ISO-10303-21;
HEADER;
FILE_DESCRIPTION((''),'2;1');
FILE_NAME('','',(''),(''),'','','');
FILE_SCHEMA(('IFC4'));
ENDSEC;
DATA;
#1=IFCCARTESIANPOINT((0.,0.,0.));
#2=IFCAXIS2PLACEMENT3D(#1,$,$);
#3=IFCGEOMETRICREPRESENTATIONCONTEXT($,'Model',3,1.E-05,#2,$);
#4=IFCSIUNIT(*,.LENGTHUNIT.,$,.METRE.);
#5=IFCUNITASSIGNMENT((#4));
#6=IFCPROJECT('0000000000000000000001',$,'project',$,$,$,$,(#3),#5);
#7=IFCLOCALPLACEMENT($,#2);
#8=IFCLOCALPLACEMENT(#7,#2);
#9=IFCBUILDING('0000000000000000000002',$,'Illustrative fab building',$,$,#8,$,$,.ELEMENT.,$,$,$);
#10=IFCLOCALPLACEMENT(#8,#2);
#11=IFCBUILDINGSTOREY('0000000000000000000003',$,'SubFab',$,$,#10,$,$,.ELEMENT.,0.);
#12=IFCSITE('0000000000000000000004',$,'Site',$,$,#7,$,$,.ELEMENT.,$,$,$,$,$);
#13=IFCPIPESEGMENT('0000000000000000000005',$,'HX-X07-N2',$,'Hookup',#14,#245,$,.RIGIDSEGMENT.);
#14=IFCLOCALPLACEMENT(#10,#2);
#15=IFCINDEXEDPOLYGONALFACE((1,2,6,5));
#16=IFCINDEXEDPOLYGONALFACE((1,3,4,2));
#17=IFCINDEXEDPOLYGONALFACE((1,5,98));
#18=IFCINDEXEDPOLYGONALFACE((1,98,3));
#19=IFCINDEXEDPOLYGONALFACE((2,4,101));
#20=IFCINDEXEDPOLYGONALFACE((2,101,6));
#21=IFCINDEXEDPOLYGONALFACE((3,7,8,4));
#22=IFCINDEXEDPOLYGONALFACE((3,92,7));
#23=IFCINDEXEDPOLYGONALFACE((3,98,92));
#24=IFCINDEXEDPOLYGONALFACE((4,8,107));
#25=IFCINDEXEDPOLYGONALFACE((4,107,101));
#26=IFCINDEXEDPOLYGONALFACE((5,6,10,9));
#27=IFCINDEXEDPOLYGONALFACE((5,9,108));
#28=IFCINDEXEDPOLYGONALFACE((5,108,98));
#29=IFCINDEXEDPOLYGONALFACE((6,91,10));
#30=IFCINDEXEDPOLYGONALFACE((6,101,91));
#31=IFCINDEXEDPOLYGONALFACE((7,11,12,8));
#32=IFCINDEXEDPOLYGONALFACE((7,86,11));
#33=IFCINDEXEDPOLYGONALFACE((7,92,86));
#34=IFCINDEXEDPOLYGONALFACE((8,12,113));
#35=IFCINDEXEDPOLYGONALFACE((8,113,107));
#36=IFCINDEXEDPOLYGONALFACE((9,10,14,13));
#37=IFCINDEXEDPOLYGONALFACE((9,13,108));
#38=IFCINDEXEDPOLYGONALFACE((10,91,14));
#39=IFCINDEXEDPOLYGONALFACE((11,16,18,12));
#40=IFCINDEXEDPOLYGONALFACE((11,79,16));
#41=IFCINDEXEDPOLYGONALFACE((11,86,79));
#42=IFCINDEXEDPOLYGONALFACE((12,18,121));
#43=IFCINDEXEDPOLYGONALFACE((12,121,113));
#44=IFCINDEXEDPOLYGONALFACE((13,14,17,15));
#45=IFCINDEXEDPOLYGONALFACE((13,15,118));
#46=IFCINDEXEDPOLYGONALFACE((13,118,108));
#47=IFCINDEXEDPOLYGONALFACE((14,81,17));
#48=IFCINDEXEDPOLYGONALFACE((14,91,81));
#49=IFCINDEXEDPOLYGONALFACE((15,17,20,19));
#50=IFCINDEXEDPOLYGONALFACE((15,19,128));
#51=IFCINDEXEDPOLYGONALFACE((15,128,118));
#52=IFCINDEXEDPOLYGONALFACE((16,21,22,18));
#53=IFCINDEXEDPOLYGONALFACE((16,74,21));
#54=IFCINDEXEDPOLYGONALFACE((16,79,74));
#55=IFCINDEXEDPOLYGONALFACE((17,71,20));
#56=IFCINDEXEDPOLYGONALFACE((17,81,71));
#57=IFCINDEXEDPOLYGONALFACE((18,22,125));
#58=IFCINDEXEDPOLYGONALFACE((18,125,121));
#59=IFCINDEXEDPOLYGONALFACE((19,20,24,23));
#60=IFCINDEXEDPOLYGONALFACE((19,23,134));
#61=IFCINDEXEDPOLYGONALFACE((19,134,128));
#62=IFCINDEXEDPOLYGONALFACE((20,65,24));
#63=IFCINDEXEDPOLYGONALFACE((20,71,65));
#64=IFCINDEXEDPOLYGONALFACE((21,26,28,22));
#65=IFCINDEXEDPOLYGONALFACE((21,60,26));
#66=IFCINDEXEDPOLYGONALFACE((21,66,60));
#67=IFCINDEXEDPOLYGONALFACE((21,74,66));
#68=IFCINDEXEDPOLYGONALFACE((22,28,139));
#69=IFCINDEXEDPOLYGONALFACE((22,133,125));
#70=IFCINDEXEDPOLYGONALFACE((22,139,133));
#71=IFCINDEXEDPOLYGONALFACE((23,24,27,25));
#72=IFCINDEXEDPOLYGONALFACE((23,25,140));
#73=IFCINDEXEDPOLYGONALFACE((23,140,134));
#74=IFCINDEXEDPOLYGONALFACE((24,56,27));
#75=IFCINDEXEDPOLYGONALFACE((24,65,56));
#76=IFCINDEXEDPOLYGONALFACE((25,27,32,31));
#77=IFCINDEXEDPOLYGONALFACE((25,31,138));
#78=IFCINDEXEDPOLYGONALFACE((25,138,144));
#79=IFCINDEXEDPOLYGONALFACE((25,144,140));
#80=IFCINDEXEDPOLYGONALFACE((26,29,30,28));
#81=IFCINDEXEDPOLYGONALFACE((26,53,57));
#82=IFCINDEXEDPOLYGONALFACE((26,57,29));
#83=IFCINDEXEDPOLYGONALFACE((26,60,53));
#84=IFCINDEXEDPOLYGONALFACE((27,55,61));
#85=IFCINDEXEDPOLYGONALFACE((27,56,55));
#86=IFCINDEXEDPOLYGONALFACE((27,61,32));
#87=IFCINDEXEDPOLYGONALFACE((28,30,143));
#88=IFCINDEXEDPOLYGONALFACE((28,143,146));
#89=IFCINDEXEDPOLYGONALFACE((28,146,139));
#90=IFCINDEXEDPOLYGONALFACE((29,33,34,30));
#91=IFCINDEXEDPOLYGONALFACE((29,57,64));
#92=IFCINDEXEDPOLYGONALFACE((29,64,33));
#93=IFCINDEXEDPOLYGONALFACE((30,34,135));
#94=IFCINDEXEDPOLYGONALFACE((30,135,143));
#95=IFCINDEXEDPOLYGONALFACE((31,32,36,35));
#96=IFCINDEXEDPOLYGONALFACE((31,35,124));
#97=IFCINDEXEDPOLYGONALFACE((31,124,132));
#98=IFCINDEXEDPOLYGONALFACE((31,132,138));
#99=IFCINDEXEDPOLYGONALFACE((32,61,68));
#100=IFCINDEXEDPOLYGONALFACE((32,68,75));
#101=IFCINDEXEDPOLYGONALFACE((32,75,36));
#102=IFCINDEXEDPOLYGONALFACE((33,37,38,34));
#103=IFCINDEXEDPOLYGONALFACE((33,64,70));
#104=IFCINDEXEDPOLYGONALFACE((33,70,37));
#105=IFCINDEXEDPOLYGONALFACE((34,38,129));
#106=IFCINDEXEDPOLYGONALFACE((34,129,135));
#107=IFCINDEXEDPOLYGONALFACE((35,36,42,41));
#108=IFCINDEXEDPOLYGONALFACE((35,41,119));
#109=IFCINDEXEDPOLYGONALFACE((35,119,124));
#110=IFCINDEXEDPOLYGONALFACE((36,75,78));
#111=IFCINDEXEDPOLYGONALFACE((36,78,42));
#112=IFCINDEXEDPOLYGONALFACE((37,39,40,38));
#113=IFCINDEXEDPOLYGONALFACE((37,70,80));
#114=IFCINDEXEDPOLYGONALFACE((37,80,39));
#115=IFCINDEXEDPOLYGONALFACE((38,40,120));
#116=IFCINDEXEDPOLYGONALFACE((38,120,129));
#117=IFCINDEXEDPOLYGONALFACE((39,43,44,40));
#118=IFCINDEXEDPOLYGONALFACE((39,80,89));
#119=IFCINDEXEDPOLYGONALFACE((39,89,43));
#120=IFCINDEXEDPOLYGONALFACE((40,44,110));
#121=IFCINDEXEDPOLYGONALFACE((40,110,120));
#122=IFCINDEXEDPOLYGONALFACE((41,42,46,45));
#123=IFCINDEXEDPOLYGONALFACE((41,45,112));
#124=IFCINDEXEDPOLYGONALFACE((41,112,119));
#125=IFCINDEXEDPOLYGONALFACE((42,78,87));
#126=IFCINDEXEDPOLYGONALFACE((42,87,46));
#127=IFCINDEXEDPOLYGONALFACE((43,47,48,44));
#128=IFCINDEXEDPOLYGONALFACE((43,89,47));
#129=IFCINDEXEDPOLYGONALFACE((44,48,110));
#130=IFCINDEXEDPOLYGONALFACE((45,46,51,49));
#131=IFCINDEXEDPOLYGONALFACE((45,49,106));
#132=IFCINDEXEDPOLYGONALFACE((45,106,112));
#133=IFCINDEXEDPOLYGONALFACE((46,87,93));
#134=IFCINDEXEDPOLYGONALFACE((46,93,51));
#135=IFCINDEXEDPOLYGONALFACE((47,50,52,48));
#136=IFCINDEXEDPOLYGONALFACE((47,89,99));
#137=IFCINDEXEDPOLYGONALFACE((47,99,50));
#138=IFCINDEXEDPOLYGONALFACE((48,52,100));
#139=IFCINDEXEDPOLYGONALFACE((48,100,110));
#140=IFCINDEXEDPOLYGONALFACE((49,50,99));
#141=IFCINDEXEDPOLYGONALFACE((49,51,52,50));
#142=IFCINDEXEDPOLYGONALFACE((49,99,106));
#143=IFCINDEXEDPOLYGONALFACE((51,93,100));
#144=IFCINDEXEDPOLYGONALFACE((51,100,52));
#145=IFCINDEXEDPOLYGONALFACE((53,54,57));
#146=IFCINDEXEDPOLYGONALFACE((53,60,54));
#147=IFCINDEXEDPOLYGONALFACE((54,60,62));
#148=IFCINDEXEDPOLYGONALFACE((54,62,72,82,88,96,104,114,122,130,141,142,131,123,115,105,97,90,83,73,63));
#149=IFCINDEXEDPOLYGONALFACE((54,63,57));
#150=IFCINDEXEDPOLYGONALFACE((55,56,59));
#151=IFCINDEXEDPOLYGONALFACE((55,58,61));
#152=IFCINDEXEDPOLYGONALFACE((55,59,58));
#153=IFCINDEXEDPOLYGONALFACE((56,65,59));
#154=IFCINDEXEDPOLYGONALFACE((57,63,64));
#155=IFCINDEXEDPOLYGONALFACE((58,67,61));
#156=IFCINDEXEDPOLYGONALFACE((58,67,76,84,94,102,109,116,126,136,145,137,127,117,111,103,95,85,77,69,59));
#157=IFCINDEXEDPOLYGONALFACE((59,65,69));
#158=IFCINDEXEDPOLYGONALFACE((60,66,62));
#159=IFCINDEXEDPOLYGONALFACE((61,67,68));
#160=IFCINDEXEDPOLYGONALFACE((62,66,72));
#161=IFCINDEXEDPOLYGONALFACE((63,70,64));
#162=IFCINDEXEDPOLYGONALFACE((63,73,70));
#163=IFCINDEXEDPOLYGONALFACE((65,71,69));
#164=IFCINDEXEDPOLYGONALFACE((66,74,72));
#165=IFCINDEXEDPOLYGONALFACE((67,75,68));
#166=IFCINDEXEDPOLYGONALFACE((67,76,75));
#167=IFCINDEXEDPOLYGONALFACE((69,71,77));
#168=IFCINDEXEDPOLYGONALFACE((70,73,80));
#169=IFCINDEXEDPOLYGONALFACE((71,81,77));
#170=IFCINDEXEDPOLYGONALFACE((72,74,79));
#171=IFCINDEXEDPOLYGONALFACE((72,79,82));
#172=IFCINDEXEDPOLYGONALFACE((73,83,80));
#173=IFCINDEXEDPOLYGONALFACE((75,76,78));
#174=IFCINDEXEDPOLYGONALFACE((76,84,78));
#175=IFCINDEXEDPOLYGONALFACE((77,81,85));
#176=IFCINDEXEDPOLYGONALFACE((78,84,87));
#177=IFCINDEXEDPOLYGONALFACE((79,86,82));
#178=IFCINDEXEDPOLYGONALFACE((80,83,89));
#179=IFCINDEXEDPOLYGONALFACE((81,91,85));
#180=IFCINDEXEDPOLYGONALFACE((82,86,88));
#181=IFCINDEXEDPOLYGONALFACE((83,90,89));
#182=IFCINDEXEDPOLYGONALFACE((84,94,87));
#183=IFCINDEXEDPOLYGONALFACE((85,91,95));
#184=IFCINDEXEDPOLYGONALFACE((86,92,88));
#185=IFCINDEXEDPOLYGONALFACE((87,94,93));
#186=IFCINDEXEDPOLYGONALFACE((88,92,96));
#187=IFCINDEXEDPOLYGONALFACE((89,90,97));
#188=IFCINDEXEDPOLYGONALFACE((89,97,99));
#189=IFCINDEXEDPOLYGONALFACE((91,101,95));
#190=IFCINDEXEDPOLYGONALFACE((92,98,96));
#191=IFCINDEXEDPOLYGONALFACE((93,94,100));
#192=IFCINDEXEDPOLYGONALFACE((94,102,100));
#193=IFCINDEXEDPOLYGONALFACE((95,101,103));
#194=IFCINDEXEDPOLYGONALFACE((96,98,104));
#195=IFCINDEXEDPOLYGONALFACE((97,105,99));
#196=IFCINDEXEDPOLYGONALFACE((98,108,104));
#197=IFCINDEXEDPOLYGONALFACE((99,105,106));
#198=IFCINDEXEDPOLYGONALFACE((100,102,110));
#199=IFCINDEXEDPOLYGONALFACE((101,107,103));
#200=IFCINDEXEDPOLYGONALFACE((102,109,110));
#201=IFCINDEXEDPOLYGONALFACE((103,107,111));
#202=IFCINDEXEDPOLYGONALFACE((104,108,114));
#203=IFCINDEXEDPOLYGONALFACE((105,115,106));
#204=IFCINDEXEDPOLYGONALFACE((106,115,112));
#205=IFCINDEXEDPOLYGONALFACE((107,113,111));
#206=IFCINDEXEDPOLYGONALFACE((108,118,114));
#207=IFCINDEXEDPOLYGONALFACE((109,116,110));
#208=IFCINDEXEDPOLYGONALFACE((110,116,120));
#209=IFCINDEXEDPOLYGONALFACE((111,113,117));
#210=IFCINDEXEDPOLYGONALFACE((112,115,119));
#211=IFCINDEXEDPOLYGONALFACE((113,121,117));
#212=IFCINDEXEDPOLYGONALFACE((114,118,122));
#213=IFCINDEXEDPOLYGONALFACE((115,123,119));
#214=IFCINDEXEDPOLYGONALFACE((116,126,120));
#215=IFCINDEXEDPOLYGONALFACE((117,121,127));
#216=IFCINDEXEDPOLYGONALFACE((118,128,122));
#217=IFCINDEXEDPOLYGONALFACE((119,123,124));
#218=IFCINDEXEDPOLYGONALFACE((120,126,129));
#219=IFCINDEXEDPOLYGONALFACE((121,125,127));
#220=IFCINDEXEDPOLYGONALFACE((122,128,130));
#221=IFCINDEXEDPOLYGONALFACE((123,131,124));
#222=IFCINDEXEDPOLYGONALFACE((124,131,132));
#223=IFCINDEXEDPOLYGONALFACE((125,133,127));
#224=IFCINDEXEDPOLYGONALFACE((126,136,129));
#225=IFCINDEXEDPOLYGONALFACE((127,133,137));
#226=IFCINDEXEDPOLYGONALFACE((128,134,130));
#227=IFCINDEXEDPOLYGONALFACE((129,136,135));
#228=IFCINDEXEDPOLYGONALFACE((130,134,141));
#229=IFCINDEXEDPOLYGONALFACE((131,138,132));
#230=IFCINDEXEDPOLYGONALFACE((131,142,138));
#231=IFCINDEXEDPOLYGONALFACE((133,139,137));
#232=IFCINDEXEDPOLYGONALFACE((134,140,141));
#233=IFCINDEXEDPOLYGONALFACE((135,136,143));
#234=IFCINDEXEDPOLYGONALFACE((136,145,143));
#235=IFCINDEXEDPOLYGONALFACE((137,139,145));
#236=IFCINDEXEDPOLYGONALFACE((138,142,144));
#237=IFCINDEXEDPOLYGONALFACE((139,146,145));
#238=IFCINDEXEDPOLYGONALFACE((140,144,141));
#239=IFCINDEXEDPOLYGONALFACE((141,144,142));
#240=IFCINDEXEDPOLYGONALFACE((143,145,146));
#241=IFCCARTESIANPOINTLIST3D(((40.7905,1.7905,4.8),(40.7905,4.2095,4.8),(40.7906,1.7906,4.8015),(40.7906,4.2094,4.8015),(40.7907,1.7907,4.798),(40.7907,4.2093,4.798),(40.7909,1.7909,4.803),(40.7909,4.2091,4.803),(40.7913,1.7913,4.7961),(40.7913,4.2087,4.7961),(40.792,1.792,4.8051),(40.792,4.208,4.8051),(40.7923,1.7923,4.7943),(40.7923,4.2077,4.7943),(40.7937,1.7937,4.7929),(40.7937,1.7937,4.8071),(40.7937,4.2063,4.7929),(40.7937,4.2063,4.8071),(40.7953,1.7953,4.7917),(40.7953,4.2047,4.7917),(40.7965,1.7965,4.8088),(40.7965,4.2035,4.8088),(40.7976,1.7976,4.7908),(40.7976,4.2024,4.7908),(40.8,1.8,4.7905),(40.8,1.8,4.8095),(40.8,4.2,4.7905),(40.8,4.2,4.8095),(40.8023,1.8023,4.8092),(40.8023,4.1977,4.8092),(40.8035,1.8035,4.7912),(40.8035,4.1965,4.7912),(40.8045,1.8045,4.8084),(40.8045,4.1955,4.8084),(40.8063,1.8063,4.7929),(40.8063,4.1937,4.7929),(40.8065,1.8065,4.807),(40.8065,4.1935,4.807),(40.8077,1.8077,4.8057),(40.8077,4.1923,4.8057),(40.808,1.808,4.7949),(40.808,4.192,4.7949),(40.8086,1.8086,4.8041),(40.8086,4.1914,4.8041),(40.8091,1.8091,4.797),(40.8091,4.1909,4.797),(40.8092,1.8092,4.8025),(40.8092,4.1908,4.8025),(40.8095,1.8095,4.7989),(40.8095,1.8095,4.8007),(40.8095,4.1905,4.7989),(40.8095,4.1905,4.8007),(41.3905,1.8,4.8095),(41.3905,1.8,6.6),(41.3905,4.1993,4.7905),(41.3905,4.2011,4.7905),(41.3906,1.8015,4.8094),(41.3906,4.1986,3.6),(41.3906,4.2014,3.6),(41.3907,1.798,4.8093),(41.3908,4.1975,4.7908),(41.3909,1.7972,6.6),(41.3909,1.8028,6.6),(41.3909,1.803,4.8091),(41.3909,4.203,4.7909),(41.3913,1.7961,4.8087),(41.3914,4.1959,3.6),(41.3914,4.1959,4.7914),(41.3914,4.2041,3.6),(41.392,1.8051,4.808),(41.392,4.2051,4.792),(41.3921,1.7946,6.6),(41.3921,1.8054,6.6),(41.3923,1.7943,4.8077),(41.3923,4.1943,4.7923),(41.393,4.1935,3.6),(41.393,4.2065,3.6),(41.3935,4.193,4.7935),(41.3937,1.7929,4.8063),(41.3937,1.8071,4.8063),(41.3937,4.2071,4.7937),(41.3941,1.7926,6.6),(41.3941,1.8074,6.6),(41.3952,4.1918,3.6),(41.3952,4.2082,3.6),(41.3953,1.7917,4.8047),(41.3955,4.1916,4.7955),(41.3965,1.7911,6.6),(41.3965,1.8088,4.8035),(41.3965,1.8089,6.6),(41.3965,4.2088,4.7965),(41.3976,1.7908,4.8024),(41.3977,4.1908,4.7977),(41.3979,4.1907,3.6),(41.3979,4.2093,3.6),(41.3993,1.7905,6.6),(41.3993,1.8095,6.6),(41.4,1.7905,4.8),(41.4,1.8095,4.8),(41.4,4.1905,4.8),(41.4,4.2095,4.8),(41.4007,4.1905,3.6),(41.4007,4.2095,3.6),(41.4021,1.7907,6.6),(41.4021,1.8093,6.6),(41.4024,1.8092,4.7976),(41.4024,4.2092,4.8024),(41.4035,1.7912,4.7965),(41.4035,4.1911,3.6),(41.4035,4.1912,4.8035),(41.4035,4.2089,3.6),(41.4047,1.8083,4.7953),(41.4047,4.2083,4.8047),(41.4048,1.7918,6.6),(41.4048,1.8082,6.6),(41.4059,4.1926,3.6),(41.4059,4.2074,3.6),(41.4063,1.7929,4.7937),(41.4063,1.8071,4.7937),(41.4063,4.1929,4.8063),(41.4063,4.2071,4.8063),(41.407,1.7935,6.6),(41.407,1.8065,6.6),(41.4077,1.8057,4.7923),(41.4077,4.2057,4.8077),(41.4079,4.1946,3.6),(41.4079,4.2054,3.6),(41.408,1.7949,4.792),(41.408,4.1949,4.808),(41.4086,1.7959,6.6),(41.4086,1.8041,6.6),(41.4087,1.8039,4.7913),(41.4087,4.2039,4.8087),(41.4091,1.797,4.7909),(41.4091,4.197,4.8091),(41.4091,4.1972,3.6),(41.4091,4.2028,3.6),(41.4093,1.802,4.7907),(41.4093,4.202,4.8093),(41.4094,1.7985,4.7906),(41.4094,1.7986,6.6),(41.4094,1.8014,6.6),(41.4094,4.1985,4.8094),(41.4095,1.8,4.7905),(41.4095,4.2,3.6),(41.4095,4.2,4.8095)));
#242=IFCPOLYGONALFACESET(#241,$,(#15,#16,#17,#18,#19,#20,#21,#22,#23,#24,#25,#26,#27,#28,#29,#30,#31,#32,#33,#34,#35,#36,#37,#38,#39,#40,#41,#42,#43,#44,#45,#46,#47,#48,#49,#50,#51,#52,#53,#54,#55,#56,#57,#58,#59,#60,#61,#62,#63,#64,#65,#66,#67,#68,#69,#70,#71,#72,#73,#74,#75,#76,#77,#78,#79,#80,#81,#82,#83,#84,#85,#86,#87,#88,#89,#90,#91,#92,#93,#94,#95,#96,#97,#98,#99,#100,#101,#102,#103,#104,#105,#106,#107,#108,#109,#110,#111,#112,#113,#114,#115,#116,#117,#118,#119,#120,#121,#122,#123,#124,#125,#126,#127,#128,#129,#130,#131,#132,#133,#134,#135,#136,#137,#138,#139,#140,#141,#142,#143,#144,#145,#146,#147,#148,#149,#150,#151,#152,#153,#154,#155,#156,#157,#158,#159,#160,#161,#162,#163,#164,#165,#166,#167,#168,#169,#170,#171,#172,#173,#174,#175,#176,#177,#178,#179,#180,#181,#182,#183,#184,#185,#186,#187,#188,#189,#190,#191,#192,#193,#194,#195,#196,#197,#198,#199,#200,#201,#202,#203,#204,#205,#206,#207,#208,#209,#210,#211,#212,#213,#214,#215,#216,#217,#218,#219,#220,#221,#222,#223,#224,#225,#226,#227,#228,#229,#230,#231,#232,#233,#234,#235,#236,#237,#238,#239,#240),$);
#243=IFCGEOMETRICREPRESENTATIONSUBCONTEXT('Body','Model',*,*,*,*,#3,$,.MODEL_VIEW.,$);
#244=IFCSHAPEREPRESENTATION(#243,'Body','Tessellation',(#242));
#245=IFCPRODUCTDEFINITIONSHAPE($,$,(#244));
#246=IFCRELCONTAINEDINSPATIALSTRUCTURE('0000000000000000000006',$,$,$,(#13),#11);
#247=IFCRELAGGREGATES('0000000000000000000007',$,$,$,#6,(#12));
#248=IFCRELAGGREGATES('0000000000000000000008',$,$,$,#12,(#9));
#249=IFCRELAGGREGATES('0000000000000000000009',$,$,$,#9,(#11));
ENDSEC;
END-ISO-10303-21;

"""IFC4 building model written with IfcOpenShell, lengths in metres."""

from ifc_helpers import new_model, entity, si_unit, origin, place, context, subcontext, project, spatial, element, save


model = new_model("IFC4")

# Units and contexts
model_context = context("Model", 3, precision=1e-05, world=origin())
body_context = subcontext(model_context, "Body", "Model", "MODEL_VIEW")
ifc_project = project(units=[si_unit("LENGTHUNIT", "METRE")], contexts=[model_context])

# Site, building, storey
site_placement = place(None, origin())
site = spatial("IfcSite", under=ifc_project, at=site_placement, Name="Site", CompositionType="ELEMENT")
building_placement = place(site_placement, origin())
building = spatial("IfcBuilding", under=site, at=building_placement, Name="Illustrative fab building", CompositionType="ELEMENT")
storey_placement = place(building_placement, origin())
storey = spatial("IfcBuildingStorey", under=building, at=storey_placement, Name="SubFab", CompositionType="ELEMENT", Elevation=0.0)

# Pipe segment
pipe_segment_1_placement = place(storey_placement, origin())
element("IfcPipeSegment", 1, at=pipe_segment_1_placement, inside=storey, Name="HX-X07-N2", ObjectType="Hookup", PredefinedType="RIGIDSEGMENT", context=body_context, shape_type="AdvancedSweptSolid", body=[
    entity("IfcSweptDiskSolid", entity("IfcPolyline", [entity("IfcCartesianPoint", [41.4, 4.2, 3.6]), entity("IfcCartesianPoint", [41.4, 4.2, 4.8]), entity("IfcCartesianPoint", [40.8, 4.2, 4.8]), entity("IfcCartesianPoint", [40.8, 1.8, 4.8]), entity("IfcCartesianPoint", [41.4, 1.8, 4.8]), entity("IfcCartesianPoint", [41.4, 1.8, 6.6])]), 0.0095),
])

save(model, "model.ifc")
